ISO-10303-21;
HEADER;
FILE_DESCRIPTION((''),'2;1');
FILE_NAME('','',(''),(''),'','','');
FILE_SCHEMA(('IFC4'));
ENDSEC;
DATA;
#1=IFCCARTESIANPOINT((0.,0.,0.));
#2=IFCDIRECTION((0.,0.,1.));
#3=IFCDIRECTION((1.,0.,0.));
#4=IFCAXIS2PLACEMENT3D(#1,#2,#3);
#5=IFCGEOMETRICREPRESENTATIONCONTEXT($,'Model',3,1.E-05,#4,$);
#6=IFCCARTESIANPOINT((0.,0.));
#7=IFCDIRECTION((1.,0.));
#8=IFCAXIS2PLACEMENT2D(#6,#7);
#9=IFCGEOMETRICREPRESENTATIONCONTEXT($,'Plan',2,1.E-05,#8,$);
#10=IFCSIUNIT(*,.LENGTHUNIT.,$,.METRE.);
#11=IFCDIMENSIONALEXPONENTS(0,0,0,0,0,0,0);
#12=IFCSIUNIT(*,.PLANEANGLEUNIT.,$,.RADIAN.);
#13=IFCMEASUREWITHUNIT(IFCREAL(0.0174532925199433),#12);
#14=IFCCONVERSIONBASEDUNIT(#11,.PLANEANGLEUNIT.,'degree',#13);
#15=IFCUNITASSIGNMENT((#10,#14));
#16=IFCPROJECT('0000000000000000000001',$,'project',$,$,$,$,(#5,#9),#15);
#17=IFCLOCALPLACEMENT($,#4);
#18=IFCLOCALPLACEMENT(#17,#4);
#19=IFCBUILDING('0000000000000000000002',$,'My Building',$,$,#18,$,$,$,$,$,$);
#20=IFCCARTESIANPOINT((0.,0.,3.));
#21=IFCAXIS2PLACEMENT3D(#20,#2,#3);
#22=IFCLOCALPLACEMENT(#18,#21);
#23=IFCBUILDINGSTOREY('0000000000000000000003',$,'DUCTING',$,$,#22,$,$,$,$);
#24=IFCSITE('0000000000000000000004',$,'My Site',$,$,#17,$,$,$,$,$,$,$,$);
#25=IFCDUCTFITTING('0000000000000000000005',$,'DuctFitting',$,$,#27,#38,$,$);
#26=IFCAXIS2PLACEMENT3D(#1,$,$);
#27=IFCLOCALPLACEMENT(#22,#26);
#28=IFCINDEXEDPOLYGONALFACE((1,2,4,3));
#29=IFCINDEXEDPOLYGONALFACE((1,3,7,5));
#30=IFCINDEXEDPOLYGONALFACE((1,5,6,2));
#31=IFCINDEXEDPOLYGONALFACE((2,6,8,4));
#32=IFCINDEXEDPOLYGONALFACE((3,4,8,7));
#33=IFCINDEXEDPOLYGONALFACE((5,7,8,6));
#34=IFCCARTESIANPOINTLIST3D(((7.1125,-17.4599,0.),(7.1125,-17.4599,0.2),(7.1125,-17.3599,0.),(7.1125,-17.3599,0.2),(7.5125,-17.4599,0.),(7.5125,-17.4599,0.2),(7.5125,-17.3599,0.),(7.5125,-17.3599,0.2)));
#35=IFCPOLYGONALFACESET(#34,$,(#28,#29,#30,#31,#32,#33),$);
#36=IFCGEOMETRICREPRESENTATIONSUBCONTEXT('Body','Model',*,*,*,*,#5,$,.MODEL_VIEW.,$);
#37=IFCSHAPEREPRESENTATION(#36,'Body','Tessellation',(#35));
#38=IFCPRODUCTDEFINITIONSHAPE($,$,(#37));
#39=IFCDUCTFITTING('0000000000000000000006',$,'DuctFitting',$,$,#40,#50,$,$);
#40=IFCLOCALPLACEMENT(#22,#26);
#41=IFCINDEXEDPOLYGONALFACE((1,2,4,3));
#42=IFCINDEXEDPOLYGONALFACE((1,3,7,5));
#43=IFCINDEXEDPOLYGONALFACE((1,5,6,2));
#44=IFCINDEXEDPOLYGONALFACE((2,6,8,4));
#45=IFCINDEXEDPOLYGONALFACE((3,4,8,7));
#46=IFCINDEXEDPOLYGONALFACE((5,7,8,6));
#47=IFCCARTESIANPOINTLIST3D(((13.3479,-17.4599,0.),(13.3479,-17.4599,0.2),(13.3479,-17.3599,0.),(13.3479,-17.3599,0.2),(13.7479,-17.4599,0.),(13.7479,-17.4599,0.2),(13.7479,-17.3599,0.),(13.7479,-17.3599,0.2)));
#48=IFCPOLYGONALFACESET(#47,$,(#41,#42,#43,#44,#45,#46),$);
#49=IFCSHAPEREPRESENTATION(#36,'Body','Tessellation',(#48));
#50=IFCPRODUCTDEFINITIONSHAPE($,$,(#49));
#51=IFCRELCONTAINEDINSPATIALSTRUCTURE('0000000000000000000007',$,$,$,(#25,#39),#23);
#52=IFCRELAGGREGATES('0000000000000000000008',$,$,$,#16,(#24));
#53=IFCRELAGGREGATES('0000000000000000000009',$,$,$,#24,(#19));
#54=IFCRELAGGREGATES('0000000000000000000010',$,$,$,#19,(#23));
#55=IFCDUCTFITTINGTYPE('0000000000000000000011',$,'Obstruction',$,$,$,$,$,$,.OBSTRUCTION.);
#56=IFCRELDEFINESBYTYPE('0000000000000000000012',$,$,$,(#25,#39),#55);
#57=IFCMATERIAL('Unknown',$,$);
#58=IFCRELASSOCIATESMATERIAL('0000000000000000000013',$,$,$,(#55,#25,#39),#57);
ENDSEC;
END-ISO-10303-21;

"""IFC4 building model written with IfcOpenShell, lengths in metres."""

from ifc_helpers import new_model, entity, si_unit, converted_unit, frame, origin_with_axes, origin_2d_with_axis, place, context, subcontext, project, spatial, rectangle, extrude, material, material_profile, profile_set, profile_usage, type_object, element, save


model = new_model("IFC4")

# Units and contexts
model_context = context("Model", 3, precision=1e-05, world=origin_with_axes())
plan_context = context("Plan", 2, precision=1e-05, world=origin_2d_with_axis())
body_context = subcontext(model_context, "Body", "Model", "MODEL_VIEW")
ifc_project = project(units=[si_unit("LENGTHUNIT", "METRE"), converted_unit("PLANEANGLEUNIT", "degree", entity("IfcReal", 0.0174532925199433), si_unit("PLANEANGLEUNIT", "RADIAN"), dimensions=[0, 0, 0, 0, 0, 0, 0])], contexts=[model_context, plan_context])

# Site, building, storey
site_placement = place(None, origin_with_axes())
site = spatial("IfcSite", under=ifc_project, at=site_placement, Name="My Site")
building_placement = place(site_placement, origin_with_axes())
building = spatial("IfcBuilding", under=site, at=building_placement, Name="My Building")
storey_placement = place(building_placement, frame((0.0, 0.0, 3.0), z_axis=(0.0, 0.0, 1.0), x_axis=(1.0, 0.0, 0.0)))
storey = spatial("IfcBuildingStorey", under=building, at=storey_placement, Name="DUCTING")

# Shared definitions
ifc_material = material(Name="Unknown")

# Duct fittings
ifc_material_profile_1 = material_profile(ifc_material, rectangle(XDim=0.4, YDim=0.2))
ifc_profile_set_1 = profile_set([ifc_material_profile_1])
duct_fitting_type_1 = type_object("IfcDuctFittingType", Name="Obstruction", PredefinedType="OBSTRUCTION", material=ifc_profile_set_1)
ifc_profile_usage_1 = profile_usage(ifc_profile_set_1, cardinal=5)
duct_fitting_1_placement = place(storey_placement, frame((7.3125, -17.4599, 0.1), z_axis=(0.000001, 1.0, 0.0), x_axis=(-1.0, 0.000001, 0.0)))
element("IfcDuctFitting", 1, at=duct_fitting_1_placement, inside=storey, type_object=duct_fitting_type_1, material=ifc_profile_usage_1, Name="DuctFitting", context=body_context, shape_type="SweptSolid", body=[
    extrude(rectangle(XDim=0.4, YDim=0.2), origin_with_axes(), (0.0, 0.0, 1.0), 0.1),
])
ifc_profile_usage_2 = profile_usage(ifc_profile_set_1, cardinal=5)
duct_fitting_2_placement = place(storey_placement, frame((13.5479, -17.4599, 0.1), z_axis=(0.000001, 1.0, 0.0), x_axis=(-1.0, 0.000001, 0.0)))
element("IfcDuctFitting", 2, at=duct_fitting_2_placement, inside=storey, type_object=duct_fitting_type_1, material=ifc_profile_usage_2, Name="DuctFitting", context=body_context, shape_type="SweptSolid", body=[
    extrude(rectangle(XDim=0.4, YDim=0.2), origin_with_axes(), (0.0, 0.0, 1.0), 0.1),
])

save(model, "model.ifc")
